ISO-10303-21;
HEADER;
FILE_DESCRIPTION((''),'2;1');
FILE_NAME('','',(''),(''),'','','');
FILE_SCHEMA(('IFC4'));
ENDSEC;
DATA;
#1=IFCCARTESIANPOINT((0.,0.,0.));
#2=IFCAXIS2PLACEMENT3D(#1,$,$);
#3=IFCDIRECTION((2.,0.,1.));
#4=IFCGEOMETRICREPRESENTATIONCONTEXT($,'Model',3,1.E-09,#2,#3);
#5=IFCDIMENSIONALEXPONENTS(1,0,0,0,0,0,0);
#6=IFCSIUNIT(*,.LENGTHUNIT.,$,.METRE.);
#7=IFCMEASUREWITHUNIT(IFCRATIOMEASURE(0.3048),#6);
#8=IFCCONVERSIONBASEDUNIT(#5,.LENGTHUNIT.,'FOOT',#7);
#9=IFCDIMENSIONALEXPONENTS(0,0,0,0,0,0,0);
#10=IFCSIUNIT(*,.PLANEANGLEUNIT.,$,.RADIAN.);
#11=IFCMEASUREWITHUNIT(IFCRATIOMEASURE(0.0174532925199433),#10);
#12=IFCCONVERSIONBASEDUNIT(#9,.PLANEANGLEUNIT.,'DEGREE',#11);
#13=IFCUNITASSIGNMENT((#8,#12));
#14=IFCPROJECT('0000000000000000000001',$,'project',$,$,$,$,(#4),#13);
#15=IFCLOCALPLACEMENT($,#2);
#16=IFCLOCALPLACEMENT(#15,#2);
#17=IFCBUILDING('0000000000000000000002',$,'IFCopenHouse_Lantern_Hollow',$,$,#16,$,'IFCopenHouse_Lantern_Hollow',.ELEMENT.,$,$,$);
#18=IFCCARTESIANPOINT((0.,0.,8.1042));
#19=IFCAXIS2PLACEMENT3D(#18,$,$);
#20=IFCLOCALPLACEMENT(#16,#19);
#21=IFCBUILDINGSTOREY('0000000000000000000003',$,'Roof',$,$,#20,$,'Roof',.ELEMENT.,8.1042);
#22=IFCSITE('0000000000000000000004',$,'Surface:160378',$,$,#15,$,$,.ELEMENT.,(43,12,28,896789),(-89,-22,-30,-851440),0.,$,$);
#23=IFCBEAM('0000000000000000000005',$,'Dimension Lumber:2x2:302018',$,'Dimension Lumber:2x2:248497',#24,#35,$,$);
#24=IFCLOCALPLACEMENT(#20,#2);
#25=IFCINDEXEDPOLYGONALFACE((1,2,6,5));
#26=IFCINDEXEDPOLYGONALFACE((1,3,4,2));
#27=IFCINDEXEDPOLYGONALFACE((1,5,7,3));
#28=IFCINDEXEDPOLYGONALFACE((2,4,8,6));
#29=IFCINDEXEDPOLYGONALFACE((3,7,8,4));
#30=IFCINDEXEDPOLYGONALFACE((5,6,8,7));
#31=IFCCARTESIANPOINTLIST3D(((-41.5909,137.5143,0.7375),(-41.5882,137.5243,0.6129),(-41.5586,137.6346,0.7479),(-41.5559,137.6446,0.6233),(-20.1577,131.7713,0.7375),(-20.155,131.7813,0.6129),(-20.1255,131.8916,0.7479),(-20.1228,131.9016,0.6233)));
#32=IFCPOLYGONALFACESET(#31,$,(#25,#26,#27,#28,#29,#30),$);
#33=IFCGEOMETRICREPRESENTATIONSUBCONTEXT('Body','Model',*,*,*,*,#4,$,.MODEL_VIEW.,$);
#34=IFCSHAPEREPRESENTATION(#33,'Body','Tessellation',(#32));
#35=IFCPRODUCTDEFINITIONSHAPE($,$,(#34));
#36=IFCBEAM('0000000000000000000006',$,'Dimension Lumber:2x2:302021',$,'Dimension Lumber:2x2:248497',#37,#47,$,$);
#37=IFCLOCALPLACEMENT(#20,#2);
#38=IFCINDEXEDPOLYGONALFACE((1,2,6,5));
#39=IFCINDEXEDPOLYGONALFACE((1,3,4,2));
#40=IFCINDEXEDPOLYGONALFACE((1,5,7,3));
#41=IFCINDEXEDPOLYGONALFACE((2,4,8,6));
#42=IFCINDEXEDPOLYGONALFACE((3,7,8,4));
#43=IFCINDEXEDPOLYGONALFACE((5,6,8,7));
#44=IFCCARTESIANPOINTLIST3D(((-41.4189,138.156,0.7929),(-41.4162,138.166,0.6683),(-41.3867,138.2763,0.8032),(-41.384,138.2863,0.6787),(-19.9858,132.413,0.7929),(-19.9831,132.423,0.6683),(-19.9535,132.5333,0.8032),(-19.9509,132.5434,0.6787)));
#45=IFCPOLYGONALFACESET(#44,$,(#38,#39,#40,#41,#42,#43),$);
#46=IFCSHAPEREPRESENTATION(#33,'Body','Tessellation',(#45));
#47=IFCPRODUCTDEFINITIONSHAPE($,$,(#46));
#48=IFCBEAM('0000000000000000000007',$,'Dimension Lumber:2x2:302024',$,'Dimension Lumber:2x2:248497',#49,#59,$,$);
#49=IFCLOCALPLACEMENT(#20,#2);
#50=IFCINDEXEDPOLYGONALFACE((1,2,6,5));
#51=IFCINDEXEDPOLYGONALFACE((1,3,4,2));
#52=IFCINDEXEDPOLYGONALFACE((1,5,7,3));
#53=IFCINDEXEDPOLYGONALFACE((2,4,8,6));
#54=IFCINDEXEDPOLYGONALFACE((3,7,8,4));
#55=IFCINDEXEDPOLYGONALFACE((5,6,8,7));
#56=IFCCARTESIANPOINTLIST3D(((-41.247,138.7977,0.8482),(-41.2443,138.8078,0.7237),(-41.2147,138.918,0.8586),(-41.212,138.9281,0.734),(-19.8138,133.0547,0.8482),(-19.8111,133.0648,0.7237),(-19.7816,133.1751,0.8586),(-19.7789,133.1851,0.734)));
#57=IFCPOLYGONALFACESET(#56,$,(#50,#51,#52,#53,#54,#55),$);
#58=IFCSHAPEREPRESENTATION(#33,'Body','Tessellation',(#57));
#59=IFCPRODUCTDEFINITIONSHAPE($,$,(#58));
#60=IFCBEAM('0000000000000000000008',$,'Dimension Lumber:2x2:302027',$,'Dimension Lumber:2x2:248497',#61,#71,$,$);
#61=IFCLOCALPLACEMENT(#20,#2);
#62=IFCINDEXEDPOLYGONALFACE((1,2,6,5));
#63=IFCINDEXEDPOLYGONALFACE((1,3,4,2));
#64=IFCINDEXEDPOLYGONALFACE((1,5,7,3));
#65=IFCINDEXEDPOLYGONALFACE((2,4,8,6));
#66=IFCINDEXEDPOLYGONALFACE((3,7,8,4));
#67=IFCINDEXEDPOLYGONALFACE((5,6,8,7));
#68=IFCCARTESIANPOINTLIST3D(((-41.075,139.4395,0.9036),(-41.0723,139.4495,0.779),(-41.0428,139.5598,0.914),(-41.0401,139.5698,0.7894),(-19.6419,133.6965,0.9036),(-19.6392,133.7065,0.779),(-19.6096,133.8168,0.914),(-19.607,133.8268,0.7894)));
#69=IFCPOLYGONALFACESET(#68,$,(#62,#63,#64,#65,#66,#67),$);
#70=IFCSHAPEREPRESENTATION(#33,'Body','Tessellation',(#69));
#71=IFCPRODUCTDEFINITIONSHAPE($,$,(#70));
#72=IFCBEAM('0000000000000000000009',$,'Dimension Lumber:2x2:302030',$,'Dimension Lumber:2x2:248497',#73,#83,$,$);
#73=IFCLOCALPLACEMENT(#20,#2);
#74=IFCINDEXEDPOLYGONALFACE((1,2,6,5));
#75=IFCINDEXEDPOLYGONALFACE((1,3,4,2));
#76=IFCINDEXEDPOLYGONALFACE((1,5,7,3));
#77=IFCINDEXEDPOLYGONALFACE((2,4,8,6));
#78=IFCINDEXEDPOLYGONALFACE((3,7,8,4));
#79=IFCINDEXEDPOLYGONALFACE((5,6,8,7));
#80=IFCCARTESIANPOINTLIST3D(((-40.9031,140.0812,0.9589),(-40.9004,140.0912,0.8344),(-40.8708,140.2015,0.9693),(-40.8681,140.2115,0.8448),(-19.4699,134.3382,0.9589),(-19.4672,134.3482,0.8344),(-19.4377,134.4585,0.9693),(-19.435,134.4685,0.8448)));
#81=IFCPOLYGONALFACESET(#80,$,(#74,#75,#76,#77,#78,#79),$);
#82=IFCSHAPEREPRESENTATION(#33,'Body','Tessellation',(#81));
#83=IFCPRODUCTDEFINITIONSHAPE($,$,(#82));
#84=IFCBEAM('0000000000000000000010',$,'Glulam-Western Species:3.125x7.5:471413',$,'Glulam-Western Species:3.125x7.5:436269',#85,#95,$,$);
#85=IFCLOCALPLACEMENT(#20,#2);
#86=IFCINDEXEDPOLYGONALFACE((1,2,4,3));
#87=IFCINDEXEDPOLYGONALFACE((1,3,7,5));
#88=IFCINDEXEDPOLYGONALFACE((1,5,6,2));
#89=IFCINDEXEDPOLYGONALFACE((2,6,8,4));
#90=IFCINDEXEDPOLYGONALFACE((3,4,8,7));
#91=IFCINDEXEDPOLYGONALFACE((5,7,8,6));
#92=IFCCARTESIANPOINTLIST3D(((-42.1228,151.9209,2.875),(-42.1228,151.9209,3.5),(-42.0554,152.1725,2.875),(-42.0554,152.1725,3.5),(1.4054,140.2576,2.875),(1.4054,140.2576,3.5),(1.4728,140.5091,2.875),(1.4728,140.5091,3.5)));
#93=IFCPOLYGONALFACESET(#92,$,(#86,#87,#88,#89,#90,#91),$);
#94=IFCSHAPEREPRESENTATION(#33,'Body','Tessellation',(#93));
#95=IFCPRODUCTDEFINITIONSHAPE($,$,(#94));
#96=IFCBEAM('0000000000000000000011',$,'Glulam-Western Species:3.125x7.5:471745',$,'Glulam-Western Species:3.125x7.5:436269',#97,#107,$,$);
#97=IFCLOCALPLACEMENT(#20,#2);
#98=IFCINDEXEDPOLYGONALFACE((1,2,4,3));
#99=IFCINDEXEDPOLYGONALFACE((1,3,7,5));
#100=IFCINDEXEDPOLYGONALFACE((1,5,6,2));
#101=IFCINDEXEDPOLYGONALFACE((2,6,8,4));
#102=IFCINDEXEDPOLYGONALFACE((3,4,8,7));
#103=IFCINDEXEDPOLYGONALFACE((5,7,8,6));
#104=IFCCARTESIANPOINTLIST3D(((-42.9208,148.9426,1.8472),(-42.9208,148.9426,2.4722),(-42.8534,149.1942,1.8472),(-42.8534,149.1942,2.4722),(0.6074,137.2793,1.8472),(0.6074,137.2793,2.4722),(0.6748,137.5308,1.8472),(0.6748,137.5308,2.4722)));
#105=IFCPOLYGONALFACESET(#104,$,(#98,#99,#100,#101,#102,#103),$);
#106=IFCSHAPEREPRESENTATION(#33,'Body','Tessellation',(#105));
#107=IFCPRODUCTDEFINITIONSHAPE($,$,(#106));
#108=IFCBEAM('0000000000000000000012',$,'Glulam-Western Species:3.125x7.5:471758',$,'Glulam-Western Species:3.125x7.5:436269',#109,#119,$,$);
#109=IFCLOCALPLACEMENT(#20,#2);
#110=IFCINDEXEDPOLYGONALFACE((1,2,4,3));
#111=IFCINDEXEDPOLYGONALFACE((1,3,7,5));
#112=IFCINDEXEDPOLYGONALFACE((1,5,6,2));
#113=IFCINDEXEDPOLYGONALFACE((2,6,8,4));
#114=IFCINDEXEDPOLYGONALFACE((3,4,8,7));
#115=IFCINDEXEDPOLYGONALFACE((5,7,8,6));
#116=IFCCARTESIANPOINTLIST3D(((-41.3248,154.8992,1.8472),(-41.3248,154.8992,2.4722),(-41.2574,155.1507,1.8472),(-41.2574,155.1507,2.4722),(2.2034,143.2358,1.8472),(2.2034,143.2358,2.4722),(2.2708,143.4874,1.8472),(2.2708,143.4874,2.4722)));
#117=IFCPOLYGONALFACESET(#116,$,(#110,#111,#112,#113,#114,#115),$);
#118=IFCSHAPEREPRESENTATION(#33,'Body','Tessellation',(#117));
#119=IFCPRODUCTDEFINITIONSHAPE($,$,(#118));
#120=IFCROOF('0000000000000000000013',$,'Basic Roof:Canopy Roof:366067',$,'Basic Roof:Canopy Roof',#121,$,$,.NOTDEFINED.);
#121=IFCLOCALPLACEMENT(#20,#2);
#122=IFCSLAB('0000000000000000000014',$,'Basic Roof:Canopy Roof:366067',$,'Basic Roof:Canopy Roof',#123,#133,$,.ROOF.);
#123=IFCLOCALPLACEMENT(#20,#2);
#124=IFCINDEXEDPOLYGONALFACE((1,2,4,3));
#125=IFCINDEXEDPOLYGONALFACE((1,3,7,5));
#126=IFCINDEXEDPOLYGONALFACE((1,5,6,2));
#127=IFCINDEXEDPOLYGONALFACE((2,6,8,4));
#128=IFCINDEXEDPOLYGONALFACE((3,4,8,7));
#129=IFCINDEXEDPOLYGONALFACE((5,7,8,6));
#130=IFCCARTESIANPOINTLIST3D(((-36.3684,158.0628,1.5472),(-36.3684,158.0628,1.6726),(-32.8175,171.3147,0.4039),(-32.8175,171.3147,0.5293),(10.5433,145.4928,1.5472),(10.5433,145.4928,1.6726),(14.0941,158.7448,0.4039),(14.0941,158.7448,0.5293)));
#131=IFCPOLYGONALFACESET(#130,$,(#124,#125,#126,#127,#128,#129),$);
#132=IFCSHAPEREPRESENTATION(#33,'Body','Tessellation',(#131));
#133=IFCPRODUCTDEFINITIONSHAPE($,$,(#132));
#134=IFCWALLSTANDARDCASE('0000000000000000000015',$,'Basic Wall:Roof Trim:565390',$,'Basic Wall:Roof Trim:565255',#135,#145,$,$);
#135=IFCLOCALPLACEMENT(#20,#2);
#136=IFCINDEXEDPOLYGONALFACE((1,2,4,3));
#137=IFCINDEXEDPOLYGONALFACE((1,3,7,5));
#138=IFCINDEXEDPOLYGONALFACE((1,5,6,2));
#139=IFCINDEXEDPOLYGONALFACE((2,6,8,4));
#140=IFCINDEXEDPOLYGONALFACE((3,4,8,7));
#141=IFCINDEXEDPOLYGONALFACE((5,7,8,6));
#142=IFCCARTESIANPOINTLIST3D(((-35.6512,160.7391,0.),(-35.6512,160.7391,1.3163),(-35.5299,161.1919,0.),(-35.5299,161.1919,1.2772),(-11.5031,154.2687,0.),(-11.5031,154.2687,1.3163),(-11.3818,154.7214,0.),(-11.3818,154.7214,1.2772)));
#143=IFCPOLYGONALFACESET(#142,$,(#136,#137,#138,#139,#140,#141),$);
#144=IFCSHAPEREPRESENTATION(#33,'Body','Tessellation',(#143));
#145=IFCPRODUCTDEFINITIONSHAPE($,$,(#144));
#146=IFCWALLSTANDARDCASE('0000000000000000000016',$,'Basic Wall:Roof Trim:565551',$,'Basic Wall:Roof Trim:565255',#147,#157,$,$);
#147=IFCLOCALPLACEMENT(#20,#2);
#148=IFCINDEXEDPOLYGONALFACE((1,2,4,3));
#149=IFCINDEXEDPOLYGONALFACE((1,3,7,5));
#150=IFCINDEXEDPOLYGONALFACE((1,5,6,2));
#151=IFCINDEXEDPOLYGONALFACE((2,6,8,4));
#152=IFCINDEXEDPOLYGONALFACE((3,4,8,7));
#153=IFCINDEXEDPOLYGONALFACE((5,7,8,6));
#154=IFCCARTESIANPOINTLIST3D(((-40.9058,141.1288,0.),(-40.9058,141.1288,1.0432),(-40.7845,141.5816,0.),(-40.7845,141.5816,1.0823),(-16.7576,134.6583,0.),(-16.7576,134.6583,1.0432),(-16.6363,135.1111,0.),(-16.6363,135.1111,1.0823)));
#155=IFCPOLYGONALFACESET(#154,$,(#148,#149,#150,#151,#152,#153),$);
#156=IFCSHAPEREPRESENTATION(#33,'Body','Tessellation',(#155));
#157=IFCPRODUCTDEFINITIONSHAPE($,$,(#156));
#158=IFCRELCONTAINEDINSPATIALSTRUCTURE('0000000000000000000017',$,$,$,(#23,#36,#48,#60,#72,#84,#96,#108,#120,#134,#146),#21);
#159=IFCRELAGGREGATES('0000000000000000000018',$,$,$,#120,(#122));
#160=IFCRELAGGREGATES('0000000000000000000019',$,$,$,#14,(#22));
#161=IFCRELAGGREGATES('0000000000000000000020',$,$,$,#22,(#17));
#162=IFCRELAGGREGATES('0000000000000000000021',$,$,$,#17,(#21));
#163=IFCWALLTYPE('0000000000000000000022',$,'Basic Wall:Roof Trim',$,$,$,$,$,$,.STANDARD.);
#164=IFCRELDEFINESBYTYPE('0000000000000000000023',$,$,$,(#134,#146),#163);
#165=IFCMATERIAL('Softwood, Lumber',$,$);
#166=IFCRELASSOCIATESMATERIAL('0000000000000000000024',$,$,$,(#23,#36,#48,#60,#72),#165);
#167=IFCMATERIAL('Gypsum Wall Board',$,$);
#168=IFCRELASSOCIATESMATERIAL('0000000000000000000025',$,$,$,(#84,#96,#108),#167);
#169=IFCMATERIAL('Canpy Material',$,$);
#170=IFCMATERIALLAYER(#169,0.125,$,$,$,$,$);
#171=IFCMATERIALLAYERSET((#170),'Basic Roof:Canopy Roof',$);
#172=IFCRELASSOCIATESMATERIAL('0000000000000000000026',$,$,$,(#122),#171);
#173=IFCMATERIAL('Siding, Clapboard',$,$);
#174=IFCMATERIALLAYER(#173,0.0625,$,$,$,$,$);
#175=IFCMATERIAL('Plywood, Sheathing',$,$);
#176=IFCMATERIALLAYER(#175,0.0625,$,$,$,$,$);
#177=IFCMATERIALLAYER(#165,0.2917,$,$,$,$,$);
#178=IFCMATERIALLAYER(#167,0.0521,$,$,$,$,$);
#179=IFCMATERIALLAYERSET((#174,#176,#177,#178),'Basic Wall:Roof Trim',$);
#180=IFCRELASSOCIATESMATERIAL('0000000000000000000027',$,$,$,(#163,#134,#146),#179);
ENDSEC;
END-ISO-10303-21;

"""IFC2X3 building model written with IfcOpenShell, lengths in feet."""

from ifc_helpers import new_model, entity, si_unit, converted_unit, direction, frame, frame_2d, origin, origin_2d_with_axis, place, context, subcontext, project, spatial, polyline, rectangle, extrude, clip, bounded_halfspace, material, layer, layer_set, layer_usage, type_object, element, aggregate, save


model = new_model("IFC2X3")

# Units and contexts
model_context = context("Model", 3, precision=1e-09, world=origin(), true_north=direction((2.0, 0.0, 1.0)))
body_context = subcontext(model_context, "Body", "Model", "MODEL_VIEW")
ifc_project = project(units=[converted_unit("LENGTHUNIT", "FOOT", entity("IfcRatioMeasure", 0.3048), si_unit("LENGTHUNIT", "METRE"), dimensions=[1, 0, 0, 0, 0, 0, 0]), converted_unit("PLANEANGLEUNIT", "DEGREE", entity("IfcRatioMeasure", 0.0174532925199433), si_unit("PLANEANGLEUNIT", "RADIAN"), dimensions=[0, 0, 0, 0, 0, 0, 0])], contexts=[model_context])

# Site, building, storey
site_placement = place(None, origin())
site = spatial("IfcSite", under=ifc_project, at=site_placement, Name="Surface:160378", CompositionType="ELEMENT", RefLatitude=(43, 12, 28, 896789), RefLongitude=(-89, -22, -30, -851440), RefElevation=0.0)
building_placement = place(site_placement, origin())
building = spatial("IfcBuilding", under=site, at=building_placement, Name="IFCopenHouse_Lantern_Hollow", LongName="IFCopenHouse_Lantern_Hollow", CompositionType="ELEMENT")
storey_placement = place(building_placement, frame((0.0, 0.0, 8.1042)))
storey = spatial("IfcBuildingStorey", under=building, at=storey_placement, Name="Roof", LongName="Roof", CompositionType="ELEMENT", Elevation=8.1042)

# Beams
ifc_material_1 = material(Name="Softwood, Lumber")
beam_1_placement = place(storey_placement, frame((-20.1416, 131.8314, 0.7427), z_axis=(0.0, 0.0, 1.0), x_axis=(-0.965926, 0.258819, 0.0)))
element("IfcBeam", 1, at=beam_1_placement, inside=storey, material=ifc_material_1, Name="Dimension Lumber:2x2:302018", ObjectType="Dimension Lumber:2x2:248497", context=body_context, shape_type="SweptSolid", body=[
    extrude(rectangle(XDim=0.125, YDim=0.125, at=frame_2d((0.0, 0.0), x_axis=(0.0, 1.0))), frame((0.0, -0.0052, -0.0623), z_axis=(1.0, 0.0, 0.0), x_axis=(0.0, -0.996546, 0.083045)), (0.0, 0.0, 1.0), 22.1892),
])
beam_2_placement = place(storey_placement, frame((-19.9697, 132.4732, 0.798), z_axis=(0.0, 0.0, 1.0), x_axis=(-0.965926, 0.258819, 0.0)))
element("IfcBeam", 2, at=beam_2_placement, inside=storey, material=ifc_material_1, Name="Dimension Lumber:2x2:302021", ObjectType="Dimension Lumber:2x2:248497", context=body_context, shape_type="SweptSolid", body=[
    extrude(rectangle(XDim=0.125, YDim=0.125, at=frame_2d((0.0, 0.0), x_axis=(0.0, 1.0))), frame((0.0, -0.0052, -0.0623), z_axis=(1.0, 0.0, 0.0), x_axis=(0.0, -0.996546, 0.083045)), (0.0, 0.0, 1.0), 22.1892),
])
beam_3_placement = place(storey_placement, frame((-19.7977, 133.1149, 0.8534), z_axis=(0.0, 0.0, 1.0), x_axis=(-0.965926, 0.258819, 0.0)))
element("IfcBeam", 3, at=beam_3_placement, inside=storey, material=ifc_material_1, Name="Dimension Lumber:2x2:302024", ObjectType="Dimension Lumber:2x2:248497", context=body_context, shape_type="SweptSolid", body=[
    extrude(rectangle(XDim=0.125, YDim=0.125, at=frame_2d((0.0, 0.0), x_axis=(0.0, 1.0))), frame((0.0, -0.0052, -0.0623), z_axis=(1.0, 0.0, 0.0), x_axis=(0.0, -0.996546, 0.083045)), (0.0, 0.0, 1.0), 22.1892),
])
for number, where, z_axis, x_axis, name in (
    (4, (-19.6258, 133.7566, 0.9088), (0.0, 0.0, 1.0), (-0.965926, 0.258819, 0.0), "Dimension Lumber:2x2:302027"),
    (5, (-19.4538, 134.3983, 0.9641), (0.0, 0.0, 1.0), (-0.965926, 0.258819, 0.0), "Dimension Lumber:2x2:302030"),
):
    element("IfcBeam", number, at=place(storey_placement, frame(where, z_axis=z_axis, x_axis=x_axis)), inside=storey, material=ifc_material_1, Name=name, ObjectType="Dimension Lumber:2x2:248497", context=body_context, shape_type="SweptSolid", body=[
        extrude(rectangle(XDim=0.125, YDim=0.125, at=frame_2d((0.0, 0.0), x_axis=(0.0, 1.0))), frame((0.0, -0.0052, -0.0623), z_axis=(1.0, 0.0, 0.0), x_axis=(0.0, -0.996546, 0.083045)), (0.0, 0.0, 1.0), 22.1892),
    ])
ifc_material_2 = material(Name="Gypsum Wall Board")
beam_4_placement = place(storey_placement, frame((-42.0891, 152.0467, 4.3333), z_axis=(0.0, 0.0, 1.0), x_axis=(0.965926, -0.258819, 0.0)))
element("IfcBeam", 6, at=beam_4_placement, inside=storey, material=ifc_material_2, Name="Glulam-Western Species:3.125x7.5:471413", ObjectType="Glulam-Western Species:3.125x7.5:436269", context=body_context, shape_type="SweptSolid", body=[
    extrude(rectangle(XDim=0.625, YDim=0.2604, at=frame_2d((0.0, 0.0), x_axis=(1.0, 0.0))), frame((0.0, 0.0, -1.1458), z_axis=(1.0, 0.0, 0.0), x_axis=(0.0, 0.0, -1.0)), (0.0, 0.0, 1.0), 45.0637),
])
for number, where, z_axis, x_axis, name in (
    (7, (-42.8871, 149.0684, 3.3056), (0.0, 0.0, 1.0), (0.965926, -0.258819, 0.0), "Glulam-Western Species:3.125x7.5:471745"),
    (8, (-41.2911, 155.025, 3.3056), (0.0, 0.0, 1.0), (0.965926, -0.258819, 0.0), "Glulam-Western Species:3.125x7.5:471758"),
):
    element("IfcBeam", number, at=place(storey_placement, frame(where, z_axis=z_axis, x_axis=x_axis)), inside=storey, material=ifc_material_2, Name=name, ObjectType="Glulam-Western Species:3.125x7.5:436269", context=body_context, shape_type="SweptSolid", body=[
        extrude(rectangle(XDim=0.625, YDim=0.2604, at=origin_2d_with_axis()), frame((0.0, 0.0, -1.1458), z_axis=(1.0, 0.0, 0.0), x_axis=(0.0, 0.0, -1.0)), (0.0, 0.0, 1.0), 45.0637),
    ])

# Roof, slab
roof_placement = place(storey_placement, frame((-36.3684, 145.4928, 0.4039)))
roof = element("IfcRoof", 9, at=roof_placement, inside=storey, Name="Basic Roof:Canopy Roof:366067", ObjectType="Basic Roof:Canopy Roof", ShapeType="NOTDEFINED")
ifc_material_3 = material(Name="Canpy Material")
ifc_layer_1 = layer(ifc_material_3, 0.125)
ifc_layer_set_1 = layer_set([ifc_layer_1], Name="Basic Roof:Canopy Roof")
slab_placement = place(roof_placement, origin())
slab = element("IfcSlab", 10, at=slab_placement, material=ifc_layer_set_1, Name="Basic Roof:Canopy Roof:366067", ObjectType="Basic Roof:Canopy Roof", PredefinedType="ROOF", context=body_context, shape_type="SweptSolid", body=[
    extrude(rectangle(XDim=48.5665, YDim=13.767, at=frame_2d((0.0, 0.0), x_axis=(0.966149, -0.257985))), frame((25.2312, 12.911, 0.5716), z_axis=(0.021494, 0.080216, 0.996546), x_axis=(0.999769, -0.001725, -0.021424)), (-0.021424, -0.080234, 0.996546), 0.1254),
])
aggregate(roof, [slab])

# Walls
ifc_material_4 = material(Name="Siding, Clapboard")
ifc_layer_2 = layer(ifc_material_4, 0.0625)
ifc_material_5 = material(Name="Plywood, Sheathing")
ifc_layer_3 = layer(ifc_material_5, 0.0625)
ifc_layer_4 = layer(ifc_material_1, 0.2917)
ifc_layer_5 = layer(ifc_material_2, 0.0521)
ifc_layer_set_2 = layer_set([ifc_layer_2, ifc_layer_3, ifc_layer_4, ifc_layer_5], Name="Basic Wall:Roof Trim")
ifc_layer_usage_1 = layer_usage(ifc_layer_set_2, "AXIS2", "POSITIVE", -0.2344)
wall_type = type_object("IfcWallType", Name="Basic Wall:Roof Trim", PredefinedType="STANDARD", material=ifc_layer_set_2)
wall_1_placement = place(storey_placement, frame((-11.4424, 154.495, 0.0), z_axis=(0.0, 0.0, 1.0), x_axis=(-0.965926, 0.258819, 0.0)))
element("IfcWallStandardCase", 11, at=wall_1_placement, inside=storey, type_object=wall_type, material=ifc_layer_usage_1, Name="Basic Wall:Roof Trim:565390", ObjectType="Basic Wall:Roof Trim:565255", context=body_context, shape_type="Clipping", body=[
    clip(extrude(rectangle(XDim=25.0, YDim=0.4688, at=frame_2d((12.5, 0.0), x_axis=(-1.0, 0.0))), origin(), (0.0, 0.0, 1.0), 1.9792), bounded_halfspace(frame((0.0, -0.2344, 1.2772), z_axis=(0.0, -0.083045, 0.996546), x_axis=(1.0, 0.0, 0.0)), False, frame((0.0, -0.2344, 1.2772)), polyline([(0.0, 0.0), (25.0, 0.0), (25.0, 0.4688), (0.0, 0.4688), (0.0, 0.0)]))),
])
ifc_layer_usage_2 = layer_usage(ifc_layer_set_2, "AXIS2", "NEGATIVE", 0.2344)
wall_2_placement = place(storey_placement, frame((-16.697, 134.8847, 0.0), z_axis=(0.0, 0.0, 1.0), x_axis=(-0.965926, 0.258819, 0.0)))
element("IfcWallStandardCase", 12, at=wall_2_placement, inside=storey, type_object=wall_type, material=ifc_layer_usage_2, Name="Basic Wall:Roof Trim:565551", ObjectType="Basic Wall:Roof Trim:565255", context=body_context, shape_type="Clipping", body=[
    clip(extrude(rectangle(XDim=25.0, YDim=0.4688, at=frame_2d((12.5, 0.0), x_axis=(-1.0, 0.0))), origin(), (0.0, 0.0, 1.0), 1.9792), bounded_halfspace(frame((0.0, -0.2344, 1.0823), z_axis=(0.0, 0.083045, 0.996546), x_axis=(-1.0, 0.0, 0.0)), False, frame((0.0, -0.2344, 1.0823)), polyline([(0.0, 0.0), (25.0, 0.0), (25.0, 0.4688), (0.0, 0.4688), (0.0, 0.0)]))),
])

save(model, "model.ifc")
